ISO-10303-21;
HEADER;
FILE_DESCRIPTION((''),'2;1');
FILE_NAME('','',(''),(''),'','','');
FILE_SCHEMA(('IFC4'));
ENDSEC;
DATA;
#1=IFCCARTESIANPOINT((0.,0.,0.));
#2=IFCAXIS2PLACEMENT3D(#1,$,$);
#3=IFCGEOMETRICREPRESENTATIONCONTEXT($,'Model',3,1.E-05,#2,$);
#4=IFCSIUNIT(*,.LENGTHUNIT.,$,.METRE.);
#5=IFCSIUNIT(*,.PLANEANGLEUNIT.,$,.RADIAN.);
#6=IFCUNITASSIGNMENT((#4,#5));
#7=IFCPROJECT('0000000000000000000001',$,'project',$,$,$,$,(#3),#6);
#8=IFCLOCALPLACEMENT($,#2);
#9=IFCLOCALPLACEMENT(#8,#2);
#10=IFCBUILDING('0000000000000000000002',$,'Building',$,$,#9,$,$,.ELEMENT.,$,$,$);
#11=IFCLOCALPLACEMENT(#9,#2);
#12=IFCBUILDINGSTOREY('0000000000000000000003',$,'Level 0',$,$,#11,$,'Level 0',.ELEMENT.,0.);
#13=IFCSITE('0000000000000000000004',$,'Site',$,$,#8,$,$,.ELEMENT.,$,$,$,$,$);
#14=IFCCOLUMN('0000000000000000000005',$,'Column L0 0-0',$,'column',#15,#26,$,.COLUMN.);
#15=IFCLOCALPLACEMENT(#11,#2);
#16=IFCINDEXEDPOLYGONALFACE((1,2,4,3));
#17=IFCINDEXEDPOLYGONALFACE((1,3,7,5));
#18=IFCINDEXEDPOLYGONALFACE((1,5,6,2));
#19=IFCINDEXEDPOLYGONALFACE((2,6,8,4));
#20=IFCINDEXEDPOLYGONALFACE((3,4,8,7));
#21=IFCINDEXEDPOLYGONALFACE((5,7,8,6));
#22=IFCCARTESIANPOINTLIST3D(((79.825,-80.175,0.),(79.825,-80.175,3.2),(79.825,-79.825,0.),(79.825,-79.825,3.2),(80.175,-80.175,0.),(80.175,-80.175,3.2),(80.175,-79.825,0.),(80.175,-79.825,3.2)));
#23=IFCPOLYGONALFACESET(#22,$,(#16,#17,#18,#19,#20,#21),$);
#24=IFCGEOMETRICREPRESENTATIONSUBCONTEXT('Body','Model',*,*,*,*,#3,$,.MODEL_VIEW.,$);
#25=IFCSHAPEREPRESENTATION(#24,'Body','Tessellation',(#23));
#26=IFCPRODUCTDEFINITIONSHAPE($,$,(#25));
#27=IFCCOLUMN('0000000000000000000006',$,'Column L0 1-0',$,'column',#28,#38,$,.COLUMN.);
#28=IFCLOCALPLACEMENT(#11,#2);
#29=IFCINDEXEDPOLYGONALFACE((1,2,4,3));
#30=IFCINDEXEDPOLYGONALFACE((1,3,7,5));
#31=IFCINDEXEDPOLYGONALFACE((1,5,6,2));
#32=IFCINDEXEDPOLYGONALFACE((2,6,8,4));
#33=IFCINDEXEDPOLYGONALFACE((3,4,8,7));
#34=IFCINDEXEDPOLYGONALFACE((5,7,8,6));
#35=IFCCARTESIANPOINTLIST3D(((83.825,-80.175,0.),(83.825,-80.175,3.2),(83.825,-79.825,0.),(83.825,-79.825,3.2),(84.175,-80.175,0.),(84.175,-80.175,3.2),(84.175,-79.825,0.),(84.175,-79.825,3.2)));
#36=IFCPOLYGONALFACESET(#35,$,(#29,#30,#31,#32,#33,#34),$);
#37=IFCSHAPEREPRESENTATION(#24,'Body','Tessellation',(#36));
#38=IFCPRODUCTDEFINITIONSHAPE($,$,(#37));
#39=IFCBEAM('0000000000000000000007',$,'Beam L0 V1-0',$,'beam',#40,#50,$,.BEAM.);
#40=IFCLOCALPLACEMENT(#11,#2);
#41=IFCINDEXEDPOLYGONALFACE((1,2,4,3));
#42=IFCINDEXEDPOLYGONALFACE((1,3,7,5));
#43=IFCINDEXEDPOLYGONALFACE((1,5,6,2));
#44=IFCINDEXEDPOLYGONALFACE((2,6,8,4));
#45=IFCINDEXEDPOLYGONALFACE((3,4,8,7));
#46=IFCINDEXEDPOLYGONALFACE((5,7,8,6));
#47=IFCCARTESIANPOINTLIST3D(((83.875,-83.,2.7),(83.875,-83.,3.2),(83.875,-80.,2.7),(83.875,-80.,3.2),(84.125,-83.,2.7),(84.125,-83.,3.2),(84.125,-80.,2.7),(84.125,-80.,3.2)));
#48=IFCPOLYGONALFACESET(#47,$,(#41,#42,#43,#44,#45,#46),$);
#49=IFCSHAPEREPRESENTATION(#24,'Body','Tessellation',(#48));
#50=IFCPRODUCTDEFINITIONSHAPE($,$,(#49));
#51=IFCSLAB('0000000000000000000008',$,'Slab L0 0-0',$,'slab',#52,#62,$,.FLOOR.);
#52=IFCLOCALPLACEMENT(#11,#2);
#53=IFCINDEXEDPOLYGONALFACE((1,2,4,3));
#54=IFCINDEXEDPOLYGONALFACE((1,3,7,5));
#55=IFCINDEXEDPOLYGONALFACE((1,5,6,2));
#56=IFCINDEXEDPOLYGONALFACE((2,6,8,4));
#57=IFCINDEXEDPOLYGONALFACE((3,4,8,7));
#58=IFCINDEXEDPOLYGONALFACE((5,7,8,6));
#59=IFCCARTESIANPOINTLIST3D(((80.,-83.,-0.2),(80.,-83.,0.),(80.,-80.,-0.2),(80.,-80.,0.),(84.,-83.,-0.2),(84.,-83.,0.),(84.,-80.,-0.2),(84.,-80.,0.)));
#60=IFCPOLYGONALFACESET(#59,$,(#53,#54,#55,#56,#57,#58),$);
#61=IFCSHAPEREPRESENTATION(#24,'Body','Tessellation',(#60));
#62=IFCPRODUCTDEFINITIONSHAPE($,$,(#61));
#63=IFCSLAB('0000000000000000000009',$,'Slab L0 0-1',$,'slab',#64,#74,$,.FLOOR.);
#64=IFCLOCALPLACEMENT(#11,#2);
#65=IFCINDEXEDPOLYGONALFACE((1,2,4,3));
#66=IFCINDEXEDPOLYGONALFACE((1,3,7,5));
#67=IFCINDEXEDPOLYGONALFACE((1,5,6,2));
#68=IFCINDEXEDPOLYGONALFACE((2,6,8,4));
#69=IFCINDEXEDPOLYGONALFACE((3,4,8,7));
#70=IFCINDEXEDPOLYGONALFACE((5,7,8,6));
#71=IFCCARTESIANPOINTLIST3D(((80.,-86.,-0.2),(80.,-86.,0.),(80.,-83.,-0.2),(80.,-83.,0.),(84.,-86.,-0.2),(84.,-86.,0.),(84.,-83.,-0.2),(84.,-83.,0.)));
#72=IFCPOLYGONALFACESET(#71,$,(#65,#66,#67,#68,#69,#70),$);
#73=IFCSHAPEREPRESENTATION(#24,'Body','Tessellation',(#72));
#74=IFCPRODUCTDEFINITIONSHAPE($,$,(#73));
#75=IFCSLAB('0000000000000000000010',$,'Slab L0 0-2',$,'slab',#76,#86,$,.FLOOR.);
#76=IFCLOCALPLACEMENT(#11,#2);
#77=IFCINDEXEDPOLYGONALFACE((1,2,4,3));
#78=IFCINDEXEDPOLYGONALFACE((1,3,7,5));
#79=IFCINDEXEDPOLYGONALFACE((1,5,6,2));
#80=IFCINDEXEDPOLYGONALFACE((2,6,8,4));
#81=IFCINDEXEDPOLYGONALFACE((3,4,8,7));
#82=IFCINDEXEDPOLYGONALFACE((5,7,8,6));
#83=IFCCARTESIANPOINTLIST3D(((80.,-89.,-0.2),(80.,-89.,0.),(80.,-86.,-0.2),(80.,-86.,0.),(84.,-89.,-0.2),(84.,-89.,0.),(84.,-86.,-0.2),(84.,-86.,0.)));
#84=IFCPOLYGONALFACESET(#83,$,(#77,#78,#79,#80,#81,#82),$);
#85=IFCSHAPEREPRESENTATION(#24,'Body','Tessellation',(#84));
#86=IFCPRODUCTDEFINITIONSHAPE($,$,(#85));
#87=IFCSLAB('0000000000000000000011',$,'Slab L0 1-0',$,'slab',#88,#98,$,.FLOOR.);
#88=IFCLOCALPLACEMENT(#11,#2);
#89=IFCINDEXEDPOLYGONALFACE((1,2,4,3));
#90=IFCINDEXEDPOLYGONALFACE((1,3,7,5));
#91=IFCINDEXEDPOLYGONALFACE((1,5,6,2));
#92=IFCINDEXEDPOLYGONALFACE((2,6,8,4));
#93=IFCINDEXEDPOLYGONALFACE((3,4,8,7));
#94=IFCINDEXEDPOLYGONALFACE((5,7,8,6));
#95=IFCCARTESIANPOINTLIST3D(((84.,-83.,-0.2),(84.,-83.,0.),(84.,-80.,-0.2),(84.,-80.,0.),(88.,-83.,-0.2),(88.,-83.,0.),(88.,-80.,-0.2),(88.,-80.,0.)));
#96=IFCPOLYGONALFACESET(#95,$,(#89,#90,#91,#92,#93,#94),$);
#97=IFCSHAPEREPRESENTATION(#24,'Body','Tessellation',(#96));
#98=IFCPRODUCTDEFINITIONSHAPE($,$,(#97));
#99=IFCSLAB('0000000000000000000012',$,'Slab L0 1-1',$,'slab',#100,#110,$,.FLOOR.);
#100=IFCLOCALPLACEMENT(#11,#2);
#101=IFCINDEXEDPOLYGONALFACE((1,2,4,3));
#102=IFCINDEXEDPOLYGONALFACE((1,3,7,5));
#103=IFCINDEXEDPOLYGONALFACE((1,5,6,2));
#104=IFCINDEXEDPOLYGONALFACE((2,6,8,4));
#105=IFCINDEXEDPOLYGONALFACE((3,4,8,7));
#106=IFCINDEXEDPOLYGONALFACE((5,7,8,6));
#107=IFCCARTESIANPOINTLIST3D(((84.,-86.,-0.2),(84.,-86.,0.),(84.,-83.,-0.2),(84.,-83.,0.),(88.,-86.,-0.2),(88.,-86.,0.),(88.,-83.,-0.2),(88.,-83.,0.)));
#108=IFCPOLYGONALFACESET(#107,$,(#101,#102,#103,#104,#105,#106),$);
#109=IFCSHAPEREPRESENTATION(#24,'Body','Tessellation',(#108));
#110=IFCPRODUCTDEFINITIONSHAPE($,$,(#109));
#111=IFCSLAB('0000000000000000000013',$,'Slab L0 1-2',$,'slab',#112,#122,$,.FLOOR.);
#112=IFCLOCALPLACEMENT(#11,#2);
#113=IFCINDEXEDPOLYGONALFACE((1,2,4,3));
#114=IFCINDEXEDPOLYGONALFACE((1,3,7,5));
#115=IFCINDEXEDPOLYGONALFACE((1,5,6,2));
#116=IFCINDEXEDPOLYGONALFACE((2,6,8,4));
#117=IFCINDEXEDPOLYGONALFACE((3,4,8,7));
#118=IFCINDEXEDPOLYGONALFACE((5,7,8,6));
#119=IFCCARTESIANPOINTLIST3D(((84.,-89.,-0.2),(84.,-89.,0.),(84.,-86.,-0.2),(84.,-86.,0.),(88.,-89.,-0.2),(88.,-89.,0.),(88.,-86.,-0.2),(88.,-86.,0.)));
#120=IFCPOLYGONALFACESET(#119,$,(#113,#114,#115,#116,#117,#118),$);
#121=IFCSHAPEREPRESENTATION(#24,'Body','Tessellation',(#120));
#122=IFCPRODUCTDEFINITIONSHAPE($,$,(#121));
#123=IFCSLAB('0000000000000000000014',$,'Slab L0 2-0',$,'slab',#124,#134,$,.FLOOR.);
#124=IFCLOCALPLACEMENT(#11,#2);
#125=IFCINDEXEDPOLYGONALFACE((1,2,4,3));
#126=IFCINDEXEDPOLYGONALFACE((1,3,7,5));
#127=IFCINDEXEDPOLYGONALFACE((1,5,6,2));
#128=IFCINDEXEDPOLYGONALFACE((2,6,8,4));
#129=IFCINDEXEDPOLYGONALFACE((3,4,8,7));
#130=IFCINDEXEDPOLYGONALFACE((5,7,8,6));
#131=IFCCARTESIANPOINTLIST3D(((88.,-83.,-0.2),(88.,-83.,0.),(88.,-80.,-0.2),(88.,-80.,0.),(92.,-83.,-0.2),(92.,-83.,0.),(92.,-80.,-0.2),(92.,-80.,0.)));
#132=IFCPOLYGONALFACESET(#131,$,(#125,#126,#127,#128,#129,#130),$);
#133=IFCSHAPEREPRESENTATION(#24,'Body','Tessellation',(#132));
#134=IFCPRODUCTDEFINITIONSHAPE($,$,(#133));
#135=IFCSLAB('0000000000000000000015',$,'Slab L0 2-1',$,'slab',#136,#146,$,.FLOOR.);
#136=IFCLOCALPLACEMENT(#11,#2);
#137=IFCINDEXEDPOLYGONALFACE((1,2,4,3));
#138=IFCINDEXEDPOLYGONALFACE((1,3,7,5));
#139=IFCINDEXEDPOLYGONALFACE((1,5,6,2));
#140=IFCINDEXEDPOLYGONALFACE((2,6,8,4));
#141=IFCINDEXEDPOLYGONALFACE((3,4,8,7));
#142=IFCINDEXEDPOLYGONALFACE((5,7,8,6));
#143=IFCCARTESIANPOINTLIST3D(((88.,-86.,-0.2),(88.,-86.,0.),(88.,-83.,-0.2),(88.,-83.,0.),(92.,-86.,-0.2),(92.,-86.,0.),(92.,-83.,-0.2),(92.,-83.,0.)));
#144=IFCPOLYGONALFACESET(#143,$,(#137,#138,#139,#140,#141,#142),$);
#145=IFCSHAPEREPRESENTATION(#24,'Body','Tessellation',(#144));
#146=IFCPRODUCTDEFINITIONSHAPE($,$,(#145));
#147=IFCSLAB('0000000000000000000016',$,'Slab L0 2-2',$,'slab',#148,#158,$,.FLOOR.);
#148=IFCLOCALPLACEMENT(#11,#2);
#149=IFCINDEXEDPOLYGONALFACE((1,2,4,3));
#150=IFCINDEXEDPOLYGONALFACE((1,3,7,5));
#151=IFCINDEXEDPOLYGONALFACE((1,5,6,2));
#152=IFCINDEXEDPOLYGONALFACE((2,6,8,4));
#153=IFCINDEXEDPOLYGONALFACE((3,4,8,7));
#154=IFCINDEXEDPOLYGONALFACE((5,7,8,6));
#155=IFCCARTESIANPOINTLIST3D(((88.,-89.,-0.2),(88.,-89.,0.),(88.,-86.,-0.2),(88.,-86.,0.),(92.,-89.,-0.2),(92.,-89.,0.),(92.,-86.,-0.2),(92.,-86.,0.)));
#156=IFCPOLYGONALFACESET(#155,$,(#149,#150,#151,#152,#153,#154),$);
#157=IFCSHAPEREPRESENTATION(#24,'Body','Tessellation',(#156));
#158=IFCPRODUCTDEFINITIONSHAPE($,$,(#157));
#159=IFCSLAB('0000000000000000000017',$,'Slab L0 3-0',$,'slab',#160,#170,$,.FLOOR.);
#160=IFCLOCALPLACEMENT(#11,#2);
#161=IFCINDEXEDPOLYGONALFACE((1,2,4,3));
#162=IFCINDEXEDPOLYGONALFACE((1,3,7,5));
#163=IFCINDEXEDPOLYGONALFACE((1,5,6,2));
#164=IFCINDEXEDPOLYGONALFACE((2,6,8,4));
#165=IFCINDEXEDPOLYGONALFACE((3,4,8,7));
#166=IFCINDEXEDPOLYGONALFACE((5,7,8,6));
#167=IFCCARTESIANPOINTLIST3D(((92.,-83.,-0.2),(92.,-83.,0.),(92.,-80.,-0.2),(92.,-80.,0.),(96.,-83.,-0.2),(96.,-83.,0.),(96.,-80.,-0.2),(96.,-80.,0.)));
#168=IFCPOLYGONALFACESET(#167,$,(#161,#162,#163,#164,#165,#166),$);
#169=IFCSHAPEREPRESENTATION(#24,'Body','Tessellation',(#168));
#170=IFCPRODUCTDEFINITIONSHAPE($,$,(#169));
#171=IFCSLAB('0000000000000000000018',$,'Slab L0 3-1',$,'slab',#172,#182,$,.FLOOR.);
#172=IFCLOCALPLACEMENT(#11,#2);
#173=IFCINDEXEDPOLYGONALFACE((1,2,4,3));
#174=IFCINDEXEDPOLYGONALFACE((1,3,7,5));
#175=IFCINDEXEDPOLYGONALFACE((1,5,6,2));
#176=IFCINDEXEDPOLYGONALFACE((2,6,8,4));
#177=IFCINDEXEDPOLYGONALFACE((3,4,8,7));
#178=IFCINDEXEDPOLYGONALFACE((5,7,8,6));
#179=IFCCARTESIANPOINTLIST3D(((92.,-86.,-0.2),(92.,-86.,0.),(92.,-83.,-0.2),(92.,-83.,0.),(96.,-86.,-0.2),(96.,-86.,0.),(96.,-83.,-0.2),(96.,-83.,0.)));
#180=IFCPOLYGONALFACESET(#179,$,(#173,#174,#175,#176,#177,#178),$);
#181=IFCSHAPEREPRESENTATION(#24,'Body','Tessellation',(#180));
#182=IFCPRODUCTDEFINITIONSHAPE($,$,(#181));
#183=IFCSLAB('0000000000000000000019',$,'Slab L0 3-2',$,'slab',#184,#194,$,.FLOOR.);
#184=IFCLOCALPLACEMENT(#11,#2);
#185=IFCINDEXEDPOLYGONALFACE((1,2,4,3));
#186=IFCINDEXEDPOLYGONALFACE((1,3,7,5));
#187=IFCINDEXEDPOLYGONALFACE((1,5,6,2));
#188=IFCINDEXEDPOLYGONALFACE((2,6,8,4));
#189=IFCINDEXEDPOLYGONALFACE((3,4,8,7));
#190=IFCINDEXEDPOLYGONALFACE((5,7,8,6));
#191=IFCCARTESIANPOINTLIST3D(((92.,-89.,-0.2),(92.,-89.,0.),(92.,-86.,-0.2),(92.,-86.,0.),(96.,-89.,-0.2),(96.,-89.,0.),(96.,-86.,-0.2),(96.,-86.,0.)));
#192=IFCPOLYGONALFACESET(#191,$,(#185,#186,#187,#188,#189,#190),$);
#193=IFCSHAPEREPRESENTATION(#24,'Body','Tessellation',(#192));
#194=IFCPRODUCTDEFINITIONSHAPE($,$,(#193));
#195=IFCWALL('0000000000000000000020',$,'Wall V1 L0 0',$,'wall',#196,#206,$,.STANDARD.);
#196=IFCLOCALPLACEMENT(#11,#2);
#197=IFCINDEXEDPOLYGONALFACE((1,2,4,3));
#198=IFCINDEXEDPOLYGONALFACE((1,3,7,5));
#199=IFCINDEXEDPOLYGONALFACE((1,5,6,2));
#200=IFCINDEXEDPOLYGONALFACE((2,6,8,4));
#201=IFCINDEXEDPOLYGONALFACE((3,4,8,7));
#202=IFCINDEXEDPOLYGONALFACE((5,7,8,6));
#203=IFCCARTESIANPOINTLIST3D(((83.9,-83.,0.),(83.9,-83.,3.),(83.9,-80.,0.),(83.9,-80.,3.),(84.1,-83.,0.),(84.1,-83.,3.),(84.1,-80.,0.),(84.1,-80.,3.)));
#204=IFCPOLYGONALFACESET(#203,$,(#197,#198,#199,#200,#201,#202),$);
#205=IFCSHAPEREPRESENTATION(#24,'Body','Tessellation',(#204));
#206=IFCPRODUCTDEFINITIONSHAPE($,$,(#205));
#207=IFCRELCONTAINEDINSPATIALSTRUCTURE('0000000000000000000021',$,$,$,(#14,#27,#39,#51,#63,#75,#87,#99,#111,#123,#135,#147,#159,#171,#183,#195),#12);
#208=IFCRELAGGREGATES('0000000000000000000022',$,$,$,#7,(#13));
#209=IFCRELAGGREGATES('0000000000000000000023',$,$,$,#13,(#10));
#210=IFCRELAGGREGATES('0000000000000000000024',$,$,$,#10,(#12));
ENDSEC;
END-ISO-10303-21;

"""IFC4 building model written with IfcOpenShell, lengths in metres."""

from ifc_helpers import new_model, si_unit, frame, frame_2d, origin, origin_2d, place, context, subcontext, project, spatial, polyline, rectangle, outline, extrude, element, save


model = new_model("IFC4")

# Units and contexts
model_context = context("Model", 3, precision=1e-05, world=origin())
body_context = subcontext(model_context, "Body", "Model", "MODEL_VIEW")
ifc_project = project(units=[si_unit("LENGTHUNIT", "METRE"), si_unit("PLANEANGLEUNIT", "RADIAN")], contexts=[model_context])

# Site, building, storey
site_placement = place(None, origin())
site = spatial("IfcSite", under=ifc_project, at=site_placement, Name="Site", CompositionType="ELEMENT")
building_placement = place(site_placement, origin())
building = spatial("IfcBuilding", under=site, at=building_placement, Name="Building", CompositionType="ELEMENT")
storey_placement = place(building_placement, origin())
storey = spatial("IfcBuildingStorey", under=building, at=storey_placement, Name="Level 0", LongName="Level 0", CompositionType="ELEMENT", Elevation=0.0)

# Columns
for number, where, name in (
    (1, (80.0, -80.0, 0.0), "Column L0 0-0"),
    (2, (84.0, -80.0, 0.0), "Column L0 1-0"),
):
    element("IfcColumn", number, at=place(storey_placement, frame(where)), inside=storey, Name=name, ObjectType="column", PredefinedType="COLUMN", context=body_context, shape_type="SweptSolid", body=[
        extrude(rectangle(XDim=0.35, YDim=0.35, at=origin_2d()), origin(), (0.0, 0.0, 1.0), 3.2),
    ])

# Beam
beam_placement = place(storey_placement, frame((84.0, -80.0, 2.95), z_axis=(0.0, -1.0, 0.0), x_axis=(0.0, 0.0, 1.0)))
element("IfcBeam", 3, at=beam_placement, inside=storey, Name="Beam L0 V1-0", ObjectType="beam", PredefinedType="BEAM", context=body_context, shape_type="SweptSolid", body=[
    extrude(rectangle(XDim=0.5, YDim=0.25, at=origin_2d()), origin(), (0.0, 0.0, 1.0), 3.0),
])

# Slabs
slab_1_placement = place(storey_placement, frame((0.0, 0.0, -0.2)))
element("IfcSlab", 4, at=slab_1_placement, inside=storey, Name="Slab L0 0-0", ObjectType="slab", PredefinedType="FLOOR", context=body_context, shape_type="SweptSolid", body=[
    extrude(outline(polyline([(80.0, -83.0), (84.0, -83.0), (84.0, -80.0), (80.0, -80.0), (80.0, -83.0)])), origin(), (0.0, 0.0, 1.0), 0.2),
])
slab_2_placement = place(storey_placement, frame((0.0, 0.0, -0.2)))
element("IfcSlab", 5, at=slab_2_placement, inside=storey, Name="Slab L0 0-1", ObjectType="slab", PredefinedType="FLOOR", context=body_context, shape_type="SweptSolid", body=[
    extrude(outline(polyline([(80.0, -86.0), (84.0, -86.0), (84.0, -83.0), (80.0, -83.0), (80.0, -86.0)])), origin(), (0.0, 0.0, 1.0), 0.2),
])
slab_3_placement = place(storey_placement, frame((0.0, 0.0, -0.2)))
element("IfcSlab", 6, at=slab_3_placement, inside=storey, Name="Slab L0 0-2", ObjectType="slab", PredefinedType="FLOOR", context=body_context, shape_type="SweptSolid", body=[
    extrude(outline(polyline([(80.0, -89.0), (84.0, -89.0), (84.0, -86.0), (80.0, -86.0), (80.0, -89.0)])), origin(), (0.0, 0.0, 1.0), 0.2),
])
slab_4_placement = place(storey_placement, frame((0.0, 0.0, -0.2)))
element("IfcSlab", 7, at=slab_4_placement, inside=storey, Name="Slab L0 1-0", ObjectType="slab", PredefinedType="FLOOR", context=body_context, shape_type="SweptSolid", body=[
    extrude(outline(polyline([(84.0, -83.0), (88.0, -83.0), (88.0, -80.0), (84.0, -80.0), (84.0, -83.0)])), origin(), (0.0, 0.0, 1.0), 0.2),
])
slab_5_placement = place(storey_placement, frame((0.0, 0.0, -0.2)))
element("IfcSlab", 8, at=slab_5_placement, inside=storey, Name="Slab L0 1-1", ObjectType="slab", PredefinedType="FLOOR", context=body_context, shape_type="SweptSolid", body=[
    extrude(outline(polyline([(84.0, -86.0), (88.0, -86.0), (88.0, -83.0), (84.0, -83.0), (84.0, -86.0)])), origin(), (0.0, 0.0, 1.0), 0.2),
])
slab_6_placement = place(storey_placement, frame((0.0, 0.0, -0.2)))
element("IfcSlab", 9, at=slab_6_placement, inside=storey, Name="Slab L0 1-2", ObjectType="slab", PredefinedType="FLOOR", context=body_context, shape_type="SweptSolid", body=[
    extrude(outline(polyline([(84.0, -89.0), (88.0, -89.0), (88.0, -86.0), (84.0, -86.0), (84.0, -89.0)])), origin(), (0.0, 0.0, 1.0), 0.2),
])
slab_7_placement = place(storey_placement, frame((0.0, 0.0, -0.2)))
element("IfcSlab", 10, at=slab_7_placement, inside=storey, Name="Slab L0 2-0", ObjectType="slab", PredefinedType="FLOOR", context=body_context, shape_type="SweptSolid", body=[
    extrude(outline(polyline([(88.0, -83.0), (92.0, -83.0), (92.0, -80.0), (88.0, -80.0), (88.0, -83.0)])), origin(), (0.0, 0.0, 1.0), 0.2),
])
slab_8_placement = place(storey_placement, frame((0.0, 0.0, -0.2)))
element("IfcSlab", 11, at=slab_8_placement, inside=storey, Name="Slab L0 2-1", ObjectType="slab", PredefinedType="FLOOR", context=body_context, shape_type="SweptSolid", body=[
    extrude(outline(polyline([(88.0, -86.0), (92.0, -86.0), (92.0, -83.0), (88.0, -83.0), (88.0, -86.0)])), origin(), (0.0, 0.0, 1.0), 0.2),
])
slab_9_placement = place(storey_placement, frame((0.0, 0.0, -0.2)))
element("IfcSlab", 12, at=slab_9_placement, inside=storey, Name="Slab L0 2-2", ObjectType="slab", PredefinedType="FLOOR", context=body_context, shape_type="SweptSolid", body=[
    extrude(outline(polyline([(88.0, -89.0), (92.0, -89.0), (92.0, -86.0), (88.0, -86.0), (88.0, -89.0)])), origin(), (0.0, 0.0, 1.0), 0.2),
])
slab_10_placement = place(storey_placement, frame((0.0, 0.0, -0.2)))
element("IfcSlab", 13, at=slab_10_placement, inside=storey, Name="Slab L0 3-0", ObjectType="slab", PredefinedType="FLOOR", context=body_context, shape_type="SweptSolid", body=[
    extrude(outline(polyline([(92.0, -83.0), (96.0, -83.0), (96.0, -80.0), (92.0, -80.0), (92.0, -83.0)])), origin(), (0.0, 0.0, 1.0), 0.2),
])
slab_11_placement = place(storey_placement, frame((0.0, 0.0, -0.2)))
element("IfcSlab", 14, at=slab_11_placement, inside=storey, Name="Slab L0 3-1", ObjectType="slab", PredefinedType="FLOOR", context=body_context, shape_type="SweptSolid", body=[
    extrude(outline(polyline([(92.0, -86.0), (96.0, -86.0), (96.0, -83.0), (92.0, -83.0), (92.0, -86.0)])), origin(), (0.0, 0.0, 1.0), 0.2),
])
slab_12_placement = place(storey_placement, frame((0.0, 0.0, -0.2)))
element("IfcSlab", 15, at=slab_12_placement, inside=storey, Name="Slab L0 3-2", ObjectType="slab", PredefinedType="FLOOR", context=body_context, shape_type="SweptSolid", body=[
    extrude(outline(polyline([(92.0, -89.0), (96.0, -89.0), (96.0, -86.0), (92.0, -86.0), (92.0, -89.0)])), origin(), (0.0, 0.0, 1.0), 0.2),
])

# Wall
wall_1_placement = place(storey_placement, frame((84.0, -80.0, 0.0), z_axis=(0.0, 0.0, 1.0), x_axis=(0.0, -1.0, 0.0)))
element("IfcWall", 16, at=wall_1_placement, inside=storey, Name="Wall V1 L0 0", ObjectType="wall", PredefinedType="STANDARD", context=body_context, shape_type="SweptSolid", body=[
    extrude(rectangle(XDim=3.0, YDim=0.2, at=frame_2d((1.5, 0.0))), origin(), (0.0, 0.0, 1.0), 3.0),
])

save(model, "model.ifc")
